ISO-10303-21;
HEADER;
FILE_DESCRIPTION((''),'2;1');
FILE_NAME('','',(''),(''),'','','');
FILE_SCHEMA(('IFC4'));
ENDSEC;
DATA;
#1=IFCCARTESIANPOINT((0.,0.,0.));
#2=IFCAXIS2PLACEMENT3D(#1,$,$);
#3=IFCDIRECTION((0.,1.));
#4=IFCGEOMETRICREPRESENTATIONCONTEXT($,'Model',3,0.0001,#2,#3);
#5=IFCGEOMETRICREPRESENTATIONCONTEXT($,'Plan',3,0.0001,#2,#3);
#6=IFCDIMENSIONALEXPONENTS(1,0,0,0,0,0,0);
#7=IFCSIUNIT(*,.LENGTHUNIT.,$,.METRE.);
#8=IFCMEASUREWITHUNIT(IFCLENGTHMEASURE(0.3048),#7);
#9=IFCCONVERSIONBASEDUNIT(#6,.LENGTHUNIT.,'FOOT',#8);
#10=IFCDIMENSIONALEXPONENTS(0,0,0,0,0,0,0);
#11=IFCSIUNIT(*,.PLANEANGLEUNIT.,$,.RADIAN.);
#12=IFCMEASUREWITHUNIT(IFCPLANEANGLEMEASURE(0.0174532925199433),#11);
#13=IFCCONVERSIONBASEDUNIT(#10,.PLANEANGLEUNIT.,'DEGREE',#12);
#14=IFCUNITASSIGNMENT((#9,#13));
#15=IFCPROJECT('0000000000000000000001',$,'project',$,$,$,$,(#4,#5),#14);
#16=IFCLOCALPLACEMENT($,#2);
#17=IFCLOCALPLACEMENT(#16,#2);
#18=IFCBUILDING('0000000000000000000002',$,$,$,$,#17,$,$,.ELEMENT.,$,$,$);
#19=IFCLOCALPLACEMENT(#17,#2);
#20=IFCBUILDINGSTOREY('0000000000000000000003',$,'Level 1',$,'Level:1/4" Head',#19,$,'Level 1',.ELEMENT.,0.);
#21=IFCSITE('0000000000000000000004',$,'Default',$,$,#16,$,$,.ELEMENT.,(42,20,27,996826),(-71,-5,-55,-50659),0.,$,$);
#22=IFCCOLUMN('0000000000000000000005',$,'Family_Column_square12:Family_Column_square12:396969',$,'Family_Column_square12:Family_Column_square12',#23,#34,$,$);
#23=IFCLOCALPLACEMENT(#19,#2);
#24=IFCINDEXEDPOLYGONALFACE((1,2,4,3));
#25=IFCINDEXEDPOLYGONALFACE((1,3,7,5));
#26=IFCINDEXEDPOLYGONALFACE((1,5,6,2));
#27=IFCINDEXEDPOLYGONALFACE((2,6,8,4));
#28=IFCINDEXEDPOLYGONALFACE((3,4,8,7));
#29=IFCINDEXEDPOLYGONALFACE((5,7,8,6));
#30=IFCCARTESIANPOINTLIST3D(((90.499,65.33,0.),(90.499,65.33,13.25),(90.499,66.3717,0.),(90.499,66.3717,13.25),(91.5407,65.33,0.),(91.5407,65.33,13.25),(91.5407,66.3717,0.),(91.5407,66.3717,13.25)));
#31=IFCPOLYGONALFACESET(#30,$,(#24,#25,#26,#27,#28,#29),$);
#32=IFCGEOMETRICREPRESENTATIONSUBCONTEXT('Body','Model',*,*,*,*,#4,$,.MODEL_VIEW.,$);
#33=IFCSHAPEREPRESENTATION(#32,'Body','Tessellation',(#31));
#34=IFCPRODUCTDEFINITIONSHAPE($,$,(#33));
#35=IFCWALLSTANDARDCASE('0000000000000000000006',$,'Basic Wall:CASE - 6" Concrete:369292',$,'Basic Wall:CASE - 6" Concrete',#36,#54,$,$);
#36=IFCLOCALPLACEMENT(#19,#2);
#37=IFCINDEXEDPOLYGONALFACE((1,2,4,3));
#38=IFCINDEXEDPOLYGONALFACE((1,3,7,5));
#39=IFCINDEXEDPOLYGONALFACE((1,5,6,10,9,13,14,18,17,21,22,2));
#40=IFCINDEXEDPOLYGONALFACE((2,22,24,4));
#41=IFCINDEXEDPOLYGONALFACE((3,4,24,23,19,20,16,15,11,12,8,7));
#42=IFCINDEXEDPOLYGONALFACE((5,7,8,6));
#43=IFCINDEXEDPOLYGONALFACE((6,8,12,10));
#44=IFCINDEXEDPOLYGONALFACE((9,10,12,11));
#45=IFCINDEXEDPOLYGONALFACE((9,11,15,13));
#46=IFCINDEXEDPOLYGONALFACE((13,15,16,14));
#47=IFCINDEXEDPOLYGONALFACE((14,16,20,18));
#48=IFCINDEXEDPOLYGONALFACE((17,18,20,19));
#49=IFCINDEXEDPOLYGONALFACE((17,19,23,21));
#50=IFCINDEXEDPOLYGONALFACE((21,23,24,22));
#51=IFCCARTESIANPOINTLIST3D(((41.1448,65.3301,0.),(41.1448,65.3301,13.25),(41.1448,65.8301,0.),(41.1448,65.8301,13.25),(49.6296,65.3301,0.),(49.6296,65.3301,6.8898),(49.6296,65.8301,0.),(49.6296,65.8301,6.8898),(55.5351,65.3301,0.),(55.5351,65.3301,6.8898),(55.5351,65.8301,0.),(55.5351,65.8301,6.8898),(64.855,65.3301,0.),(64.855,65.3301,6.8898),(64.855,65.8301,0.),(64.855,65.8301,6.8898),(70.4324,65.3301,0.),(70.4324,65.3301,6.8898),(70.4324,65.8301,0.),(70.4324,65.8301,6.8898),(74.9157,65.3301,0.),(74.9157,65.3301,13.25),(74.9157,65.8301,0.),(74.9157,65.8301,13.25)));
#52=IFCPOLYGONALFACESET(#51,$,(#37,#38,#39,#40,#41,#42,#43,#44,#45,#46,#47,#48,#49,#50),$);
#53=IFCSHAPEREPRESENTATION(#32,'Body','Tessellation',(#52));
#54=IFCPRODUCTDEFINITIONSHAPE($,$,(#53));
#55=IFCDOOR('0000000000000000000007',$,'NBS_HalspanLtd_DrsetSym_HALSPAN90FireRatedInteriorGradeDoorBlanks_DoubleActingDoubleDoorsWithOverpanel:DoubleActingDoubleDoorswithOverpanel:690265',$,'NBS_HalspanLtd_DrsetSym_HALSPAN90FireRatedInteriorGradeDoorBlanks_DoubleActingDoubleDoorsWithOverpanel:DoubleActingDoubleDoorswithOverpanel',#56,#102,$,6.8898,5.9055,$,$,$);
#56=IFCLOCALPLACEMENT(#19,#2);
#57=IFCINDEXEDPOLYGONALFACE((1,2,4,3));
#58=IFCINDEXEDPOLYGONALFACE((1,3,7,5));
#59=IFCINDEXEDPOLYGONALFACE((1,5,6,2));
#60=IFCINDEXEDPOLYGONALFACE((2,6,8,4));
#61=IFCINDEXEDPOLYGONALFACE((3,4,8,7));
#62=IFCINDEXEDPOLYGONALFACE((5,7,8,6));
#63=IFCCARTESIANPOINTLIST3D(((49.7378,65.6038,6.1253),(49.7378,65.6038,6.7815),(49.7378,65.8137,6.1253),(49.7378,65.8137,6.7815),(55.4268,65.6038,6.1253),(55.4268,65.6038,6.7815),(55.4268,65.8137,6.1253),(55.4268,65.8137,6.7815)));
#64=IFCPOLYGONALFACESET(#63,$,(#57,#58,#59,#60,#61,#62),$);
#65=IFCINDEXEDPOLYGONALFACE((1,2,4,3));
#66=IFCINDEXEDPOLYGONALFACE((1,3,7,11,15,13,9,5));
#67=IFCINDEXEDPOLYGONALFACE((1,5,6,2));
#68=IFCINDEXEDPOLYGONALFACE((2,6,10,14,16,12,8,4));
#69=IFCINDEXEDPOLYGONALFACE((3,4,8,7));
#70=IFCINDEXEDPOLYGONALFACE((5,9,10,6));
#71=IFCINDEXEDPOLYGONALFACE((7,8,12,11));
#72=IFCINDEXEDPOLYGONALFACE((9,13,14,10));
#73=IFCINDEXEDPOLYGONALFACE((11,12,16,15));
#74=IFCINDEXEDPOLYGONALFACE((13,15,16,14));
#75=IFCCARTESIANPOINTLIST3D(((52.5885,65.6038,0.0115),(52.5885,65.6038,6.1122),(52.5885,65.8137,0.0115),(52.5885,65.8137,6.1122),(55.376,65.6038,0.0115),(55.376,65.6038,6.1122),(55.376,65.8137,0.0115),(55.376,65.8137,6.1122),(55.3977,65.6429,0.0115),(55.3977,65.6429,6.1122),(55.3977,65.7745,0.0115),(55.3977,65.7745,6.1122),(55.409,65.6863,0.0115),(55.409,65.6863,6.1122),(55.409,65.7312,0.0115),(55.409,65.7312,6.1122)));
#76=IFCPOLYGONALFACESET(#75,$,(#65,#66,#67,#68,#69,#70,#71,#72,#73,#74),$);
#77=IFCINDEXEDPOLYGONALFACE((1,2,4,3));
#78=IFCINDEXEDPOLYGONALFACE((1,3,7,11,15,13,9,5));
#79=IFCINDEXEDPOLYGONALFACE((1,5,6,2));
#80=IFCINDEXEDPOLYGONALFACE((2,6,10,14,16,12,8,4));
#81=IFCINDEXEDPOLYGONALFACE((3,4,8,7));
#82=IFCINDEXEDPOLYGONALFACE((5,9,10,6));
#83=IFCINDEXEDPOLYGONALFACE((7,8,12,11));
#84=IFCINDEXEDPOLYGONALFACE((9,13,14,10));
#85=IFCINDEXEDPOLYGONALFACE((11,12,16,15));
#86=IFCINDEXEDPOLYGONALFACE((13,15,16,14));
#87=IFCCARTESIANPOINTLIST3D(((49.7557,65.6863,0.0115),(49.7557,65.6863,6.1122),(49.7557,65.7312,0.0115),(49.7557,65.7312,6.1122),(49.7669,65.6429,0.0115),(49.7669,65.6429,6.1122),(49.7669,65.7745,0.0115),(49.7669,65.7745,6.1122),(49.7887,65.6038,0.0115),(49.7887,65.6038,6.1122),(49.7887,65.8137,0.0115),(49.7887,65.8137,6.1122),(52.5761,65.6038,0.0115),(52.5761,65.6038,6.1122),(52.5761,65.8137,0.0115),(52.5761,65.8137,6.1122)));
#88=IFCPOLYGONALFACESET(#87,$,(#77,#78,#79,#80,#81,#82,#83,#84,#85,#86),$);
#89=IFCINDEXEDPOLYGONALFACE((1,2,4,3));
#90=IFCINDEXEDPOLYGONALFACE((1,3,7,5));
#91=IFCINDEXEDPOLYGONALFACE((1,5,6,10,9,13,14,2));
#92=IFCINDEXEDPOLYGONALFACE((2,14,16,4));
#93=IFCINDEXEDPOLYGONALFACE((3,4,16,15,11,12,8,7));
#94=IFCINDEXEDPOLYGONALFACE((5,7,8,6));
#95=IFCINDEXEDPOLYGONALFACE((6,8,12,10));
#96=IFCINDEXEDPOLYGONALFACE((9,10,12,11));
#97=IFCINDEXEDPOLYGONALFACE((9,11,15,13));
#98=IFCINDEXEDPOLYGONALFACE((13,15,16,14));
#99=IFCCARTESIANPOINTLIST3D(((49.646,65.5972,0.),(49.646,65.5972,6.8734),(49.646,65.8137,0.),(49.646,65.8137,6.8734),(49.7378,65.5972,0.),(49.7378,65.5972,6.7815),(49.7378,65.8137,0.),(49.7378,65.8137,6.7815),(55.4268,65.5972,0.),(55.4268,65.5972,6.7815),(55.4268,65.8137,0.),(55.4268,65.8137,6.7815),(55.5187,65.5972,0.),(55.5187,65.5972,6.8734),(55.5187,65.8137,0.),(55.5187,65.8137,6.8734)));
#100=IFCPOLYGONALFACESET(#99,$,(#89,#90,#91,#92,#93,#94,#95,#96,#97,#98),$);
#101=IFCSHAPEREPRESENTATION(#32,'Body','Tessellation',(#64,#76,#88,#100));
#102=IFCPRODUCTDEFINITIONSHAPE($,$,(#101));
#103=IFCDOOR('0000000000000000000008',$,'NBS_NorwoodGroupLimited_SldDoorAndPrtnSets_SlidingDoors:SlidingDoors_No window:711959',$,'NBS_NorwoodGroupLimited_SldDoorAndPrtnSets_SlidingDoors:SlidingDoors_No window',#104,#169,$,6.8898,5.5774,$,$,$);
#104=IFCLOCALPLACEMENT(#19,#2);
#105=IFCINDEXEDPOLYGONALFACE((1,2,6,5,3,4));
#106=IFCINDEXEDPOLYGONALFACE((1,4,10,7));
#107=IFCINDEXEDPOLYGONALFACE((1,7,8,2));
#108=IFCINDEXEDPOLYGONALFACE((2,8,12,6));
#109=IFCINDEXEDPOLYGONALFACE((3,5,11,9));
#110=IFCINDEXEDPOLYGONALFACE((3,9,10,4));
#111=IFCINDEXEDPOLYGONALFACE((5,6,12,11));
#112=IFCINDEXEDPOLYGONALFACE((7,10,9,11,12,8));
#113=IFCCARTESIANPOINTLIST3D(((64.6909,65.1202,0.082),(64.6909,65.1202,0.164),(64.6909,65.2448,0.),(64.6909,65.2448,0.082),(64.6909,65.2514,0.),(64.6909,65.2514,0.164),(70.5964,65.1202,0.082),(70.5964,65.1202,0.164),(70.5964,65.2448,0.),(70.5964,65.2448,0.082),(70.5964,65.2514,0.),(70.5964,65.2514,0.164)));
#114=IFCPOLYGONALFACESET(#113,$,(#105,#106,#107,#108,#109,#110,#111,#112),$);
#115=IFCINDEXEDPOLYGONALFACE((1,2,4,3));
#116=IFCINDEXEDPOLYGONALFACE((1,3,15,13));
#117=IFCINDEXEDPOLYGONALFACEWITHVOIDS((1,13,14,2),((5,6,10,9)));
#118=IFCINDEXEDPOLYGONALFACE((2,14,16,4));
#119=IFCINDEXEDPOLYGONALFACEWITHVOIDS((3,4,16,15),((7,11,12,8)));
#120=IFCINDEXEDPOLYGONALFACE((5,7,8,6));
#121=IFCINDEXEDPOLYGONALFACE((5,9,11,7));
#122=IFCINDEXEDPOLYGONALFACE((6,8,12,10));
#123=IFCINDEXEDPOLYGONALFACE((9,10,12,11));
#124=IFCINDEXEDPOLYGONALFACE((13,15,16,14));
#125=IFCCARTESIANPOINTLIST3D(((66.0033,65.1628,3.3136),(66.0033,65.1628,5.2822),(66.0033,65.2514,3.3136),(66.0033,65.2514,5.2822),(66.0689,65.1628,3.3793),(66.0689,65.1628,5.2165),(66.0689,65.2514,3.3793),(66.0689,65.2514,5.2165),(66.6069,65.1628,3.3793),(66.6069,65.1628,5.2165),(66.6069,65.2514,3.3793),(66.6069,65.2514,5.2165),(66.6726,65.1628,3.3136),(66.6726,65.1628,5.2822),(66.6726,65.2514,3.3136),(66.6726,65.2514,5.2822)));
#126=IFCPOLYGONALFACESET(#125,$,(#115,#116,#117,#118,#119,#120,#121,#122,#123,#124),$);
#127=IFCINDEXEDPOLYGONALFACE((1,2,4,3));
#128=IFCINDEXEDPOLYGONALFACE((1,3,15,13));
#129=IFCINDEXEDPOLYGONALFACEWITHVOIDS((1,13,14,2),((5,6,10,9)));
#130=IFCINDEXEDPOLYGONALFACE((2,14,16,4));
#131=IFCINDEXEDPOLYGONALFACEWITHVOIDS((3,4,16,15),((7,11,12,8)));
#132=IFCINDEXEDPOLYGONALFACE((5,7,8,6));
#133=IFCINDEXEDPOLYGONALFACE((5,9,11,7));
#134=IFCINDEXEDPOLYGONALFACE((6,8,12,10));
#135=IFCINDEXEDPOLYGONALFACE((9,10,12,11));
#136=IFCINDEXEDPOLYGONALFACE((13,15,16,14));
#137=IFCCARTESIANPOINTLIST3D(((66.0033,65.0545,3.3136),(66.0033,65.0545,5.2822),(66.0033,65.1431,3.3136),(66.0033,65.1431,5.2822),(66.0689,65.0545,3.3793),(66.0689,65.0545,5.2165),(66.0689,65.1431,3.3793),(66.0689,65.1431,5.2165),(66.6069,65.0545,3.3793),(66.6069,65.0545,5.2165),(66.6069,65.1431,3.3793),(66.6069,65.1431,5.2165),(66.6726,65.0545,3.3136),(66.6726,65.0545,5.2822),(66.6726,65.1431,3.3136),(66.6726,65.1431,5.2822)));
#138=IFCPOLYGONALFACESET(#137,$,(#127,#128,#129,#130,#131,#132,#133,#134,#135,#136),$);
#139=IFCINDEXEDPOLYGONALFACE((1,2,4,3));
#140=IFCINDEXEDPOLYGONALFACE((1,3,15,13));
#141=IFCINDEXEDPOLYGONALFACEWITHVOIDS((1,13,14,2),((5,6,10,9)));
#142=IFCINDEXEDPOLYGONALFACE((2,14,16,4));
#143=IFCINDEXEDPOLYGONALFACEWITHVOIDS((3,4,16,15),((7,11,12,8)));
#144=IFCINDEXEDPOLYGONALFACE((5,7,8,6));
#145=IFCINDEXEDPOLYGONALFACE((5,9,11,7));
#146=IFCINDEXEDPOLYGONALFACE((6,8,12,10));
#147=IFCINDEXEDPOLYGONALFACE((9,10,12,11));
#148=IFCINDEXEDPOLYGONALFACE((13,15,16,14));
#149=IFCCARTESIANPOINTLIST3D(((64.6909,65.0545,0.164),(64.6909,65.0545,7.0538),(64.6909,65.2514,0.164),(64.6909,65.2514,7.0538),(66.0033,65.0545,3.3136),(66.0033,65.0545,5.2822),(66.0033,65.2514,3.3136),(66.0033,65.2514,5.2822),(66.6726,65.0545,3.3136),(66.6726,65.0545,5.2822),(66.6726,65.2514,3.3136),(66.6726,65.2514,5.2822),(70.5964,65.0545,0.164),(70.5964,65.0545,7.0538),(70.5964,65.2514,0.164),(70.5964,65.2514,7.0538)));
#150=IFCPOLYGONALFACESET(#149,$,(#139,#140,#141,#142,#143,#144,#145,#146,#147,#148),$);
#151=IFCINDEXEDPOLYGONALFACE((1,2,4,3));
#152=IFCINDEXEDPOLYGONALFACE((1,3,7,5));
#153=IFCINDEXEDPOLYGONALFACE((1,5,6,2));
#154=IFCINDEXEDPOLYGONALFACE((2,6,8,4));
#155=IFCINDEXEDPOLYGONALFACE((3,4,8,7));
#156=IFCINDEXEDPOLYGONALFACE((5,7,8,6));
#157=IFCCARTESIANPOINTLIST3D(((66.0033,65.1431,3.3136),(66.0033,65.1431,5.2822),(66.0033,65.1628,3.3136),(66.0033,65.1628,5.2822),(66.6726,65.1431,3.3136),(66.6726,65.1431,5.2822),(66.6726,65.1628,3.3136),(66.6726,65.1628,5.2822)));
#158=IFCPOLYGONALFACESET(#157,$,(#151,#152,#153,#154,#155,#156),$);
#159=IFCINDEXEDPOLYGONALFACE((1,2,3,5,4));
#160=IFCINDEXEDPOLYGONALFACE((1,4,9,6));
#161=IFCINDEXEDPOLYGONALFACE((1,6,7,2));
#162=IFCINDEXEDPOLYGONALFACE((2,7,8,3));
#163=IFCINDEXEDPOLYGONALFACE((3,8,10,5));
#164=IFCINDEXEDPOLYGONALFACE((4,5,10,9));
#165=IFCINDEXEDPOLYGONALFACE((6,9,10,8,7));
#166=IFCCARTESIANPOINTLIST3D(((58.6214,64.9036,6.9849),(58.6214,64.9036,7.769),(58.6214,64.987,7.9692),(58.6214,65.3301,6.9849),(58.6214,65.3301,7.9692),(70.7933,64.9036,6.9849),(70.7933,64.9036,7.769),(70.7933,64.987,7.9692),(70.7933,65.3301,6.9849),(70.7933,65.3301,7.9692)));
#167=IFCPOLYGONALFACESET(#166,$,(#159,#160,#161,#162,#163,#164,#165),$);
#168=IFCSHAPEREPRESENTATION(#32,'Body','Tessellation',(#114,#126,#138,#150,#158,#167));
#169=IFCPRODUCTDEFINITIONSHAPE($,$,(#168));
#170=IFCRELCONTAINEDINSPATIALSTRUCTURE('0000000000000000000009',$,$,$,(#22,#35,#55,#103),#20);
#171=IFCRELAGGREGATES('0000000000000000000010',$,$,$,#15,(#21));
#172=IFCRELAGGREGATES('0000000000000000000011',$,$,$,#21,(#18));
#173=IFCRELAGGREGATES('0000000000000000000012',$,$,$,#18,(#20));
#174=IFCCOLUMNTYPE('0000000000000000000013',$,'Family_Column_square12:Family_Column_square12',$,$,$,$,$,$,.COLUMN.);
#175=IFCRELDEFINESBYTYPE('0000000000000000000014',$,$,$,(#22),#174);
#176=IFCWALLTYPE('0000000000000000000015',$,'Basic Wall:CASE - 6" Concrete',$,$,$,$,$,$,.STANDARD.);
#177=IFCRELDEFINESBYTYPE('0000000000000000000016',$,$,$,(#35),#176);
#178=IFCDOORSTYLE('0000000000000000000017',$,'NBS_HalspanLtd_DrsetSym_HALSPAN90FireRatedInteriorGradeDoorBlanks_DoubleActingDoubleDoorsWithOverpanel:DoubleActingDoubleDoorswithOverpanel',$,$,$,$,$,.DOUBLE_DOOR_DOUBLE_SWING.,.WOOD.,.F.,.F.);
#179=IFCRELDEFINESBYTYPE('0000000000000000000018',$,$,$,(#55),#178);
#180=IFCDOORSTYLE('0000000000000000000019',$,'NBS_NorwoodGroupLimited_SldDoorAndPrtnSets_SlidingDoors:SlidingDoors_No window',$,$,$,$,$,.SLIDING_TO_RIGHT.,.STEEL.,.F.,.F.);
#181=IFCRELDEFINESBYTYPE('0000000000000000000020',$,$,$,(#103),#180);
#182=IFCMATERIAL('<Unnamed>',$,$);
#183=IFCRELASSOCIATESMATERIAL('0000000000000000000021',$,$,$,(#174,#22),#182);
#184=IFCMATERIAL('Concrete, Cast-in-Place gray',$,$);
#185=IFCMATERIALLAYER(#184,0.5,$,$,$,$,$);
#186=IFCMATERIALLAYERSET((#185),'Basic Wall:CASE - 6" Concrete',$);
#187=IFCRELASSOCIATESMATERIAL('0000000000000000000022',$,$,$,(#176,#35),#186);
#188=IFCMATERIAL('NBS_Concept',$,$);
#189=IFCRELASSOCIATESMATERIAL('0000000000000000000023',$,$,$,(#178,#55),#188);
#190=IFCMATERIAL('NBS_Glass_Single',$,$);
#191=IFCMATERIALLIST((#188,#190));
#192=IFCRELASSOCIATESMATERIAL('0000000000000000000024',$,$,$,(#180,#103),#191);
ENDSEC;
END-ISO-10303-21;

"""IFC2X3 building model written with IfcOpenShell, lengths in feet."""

from ifc_helpers import new_model, entity, si_unit, converted_unit, direction, frame, frame_2d, origin, origin_2d_with_axis, place, context, subcontext, project, spatial, polyline, circle_curve, parameter, trimmed, segment, composite_curve, rectangle, outline, extrude, source, transform, mapped, material, material_list, layer, layer_set, layer_usage, type_object, type_shapes, element, fill, save


model = new_model("IFC2X3")

# Units and contexts
model_context = context("Model", 3, precision=0.0001, world=origin(), true_north=direction((0.0, 1.0)))
plan_context = context("Plan", 3, precision=0.0001, world=origin(), true_north=direction((0.0, 1.0)))
body_context = subcontext(model_context, "Body", "Model", "MODEL_VIEW")
ifc_project = project(units=[converted_unit("LENGTHUNIT", "FOOT", entity("IfcLengthMeasure", 0.3048), si_unit("LENGTHUNIT", "METRE"), dimensions=[1, 0, 0, 0, 0, 0, 0]), converted_unit("PLANEANGLEUNIT", "DEGREE", entity("IfcPlaneAngleMeasure", 0.0174532925199433), si_unit("PLANEANGLEUNIT", "RADIAN"), dimensions=[0, 0, 0, 0, 0, 0, 0])], contexts=[model_context, plan_context])

# Site, building, storey
site_placement = place(None, origin())
site = spatial("IfcSite", under=ifc_project, at=site_placement, Name="Default", CompositionType="ELEMENT", RefLatitude=(42, 20, 27, 996826), RefLongitude=(-71, -5, -55, -50659), RefElevation=0.0)
building_placement = place(site_placement, origin())
building = spatial("IfcBuilding", under=site, at=building_placement, CompositionType="ELEMENT")
storey_placement = place(building_placement, origin())
storey = spatial("IfcBuildingStorey", under=building, at=storey_placement, Name="Level 1", ObjectType="Level:1/4\" Head", LongName="Level 1", CompositionType="ELEMENT", Elevation=0.0)

# Column
ifc_material_1 = material(Name="<Unnamed>")
column_type = type_object("IfcColumnType", Name="Family_Column_square12:Family_Column_square12", PredefinedType="COLUMN", material=ifc_material_1)
shared_shape_1 = source(origin(), body_context, "Body", "SweptSolid", [
    extrude(rectangle(XDim=1.0417, YDim=1.0417, at=frame_2d((0.0, 0.0), x_axis=(1.0, 0.0))), frame((0.0, 0.0, 0.0), z_axis=(0.0, 0.0, 1.0), x_axis=(-1.0, 0.0, 0.0)), (0.0, 0.0, 1.0), 13.25),
])
type_shapes(column_type, [shared_shape_1])
column_placement = place(storey_placement, frame((91.0198, 65.8509, 0.0)))
element("IfcColumn", 1, at=column_placement, inside=storey, type_object=column_type, material=ifc_material_1, Name="Family_Column_square12:Family_Column_square12:396969", ObjectType="Family_Column_square12:Family_Column_square12", context=body_context, shape_type="MappedRepresentation", body=[
    mapped(shared_shape_1, transform((0.0, 0.0, 0.0), scale=1.0)),
])

# Wall, openings, doors
ifc_material_2 = material(Name="Concrete, Cast-in-Place gray")
ifc_layer = layer(ifc_material_2, 0.5)
ifc_layer_set = layer_set([ifc_layer], Name="Basic Wall:CASE - 6\" Concrete")
ifc_layer_usage_1 = layer_usage(ifc_layer_set, "AXIS2", "NEGATIVE", 0.25)
wall_type = type_object("IfcWallType", Name="Basic Wall:CASE - 6\" Concrete", PredefinedType="STANDARD", material=ifc_layer_set)
wall_1_placement = place(storey_placement, frame((74.9157, 65.5801, 0.0), z_axis=(0.0, 0.0, 1.0), x_axis=(-1.0, 0.0, 0.0)))
wall_1 = element("IfcWallStandardCase", 2, at=wall_1_placement, inside=storey, type_object=wall_type, material=ifc_layer_usage_1, Name="Basic Wall:CASE - 6\" Concrete:369292", ObjectType="Basic Wall:CASE - 6\" Concrete", context=body_context, shape_type="SweptSolid", body=[
    extrude(rectangle(XDim=33.7708, YDim=0.5, at=frame_2d((16.8854, 0.0), x_axis=(1.0, 0.0))), origin(), (0.0, 0.0, 1.0), 13.25),
])
opening_1_placement = place(wall_1_placement, frame((74.9157, 65.5801, 0.0), z_axis=(0.0, 0.0, 1.0), x_axis=(-1.0, 0.0, 0.0)))
opening_1 = element("IfcOpeningElement", 3, at=opening_1_placement, cuts=wall_1, ObjectType="Opening", context=body_context, shape_type="SweptSolid", body=[
    extrude(rectangle(XDim=6.8898, YDim=5.9055, at=frame_2d((0.0, 0.0), x_axis=(0.0, 1.0))), frame((52.5823, 65.8465, 3.4449), z_axis=(0.0, -1.0, 0.0), x_axis=(-1.0, 0.0, 0.0)), (0.0, 0.0, 1.0), 0.5328),
])
opening_2_placement = place(wall_1_placement, frame((10.0607, 0.25, 0.0)))
opening_2 = element("IfcOpeningElement", 4, at=opening_2_placement, cuts=wall_1, ObjectType="Opening", context=body_context, shape_type="SweptSolid", body=[
    extrude(rectangle(XDim=5.5774, YDim=6.8898, at=frame_2d((3.4449, 2.7887), x_axis=(0.0, -1.0))), frame((0.0, 0.0, 0.0), z_axis=(0.0, -1.0, 0.0), x_axis=(0.0, 0.0, 1.0)), (0.0, 0.0, 1.0), 0.5),
])
ifc_material_3 = material(Name="NBS_Concept")
door_style_1 = type_object("IfcDoorStyle", Name="NBS_HalspanLtd_DrsetSym_HALSPAN90FireRatedInteriorGradeDoorBlanks_DoubleActingDoubleDoorsWithOverpanel:DoubleActingDoubleDoorswithOverpanel", ConstructionType="WOOD", OperationType="DOUBLE_DOOR_DOUBLE_SWING", ParameterTakesPrecedence=False, Sizeable=False, material=ifc_material_3)
shared_shape_2 = source(origin(), body_context, "Body", "SweptSolid", [
    extrude(rectangle(XDim=5.689, YDim=0.21, at=frame_2d((0.0, 0.0), x_axis=(1.0, 0.0))), frame((2.9528, -0.1378, 6.1253), z_axis=(0.0, 0.0, 1.0), x_axis=(-1.0, 0.0, 0.0)), (0.0, 0.0, 1.0), 0.6562),
    extrude(outline(composite_curve([segment(polyline([(-0.105, -1.3937), (0.105, -1.3937)]), True, "CONTINUOUS"), segment(polyline([(0.105, -1.3937), (0.105, 1.3937)]), True, "CONTINUOUS"), segment(trimmed(circle_curve(frame_2d((0.0, 1.251), x_axis=(0.0, 1.0)), 0.1772), [parameter(323.658797)], [parameter(36.341203)], True, "PARAMETER"), True, "CONTINUOUS"), segment(polyline([(-0.105, 1.3937), (-0.105, -1.3937)]), True, "CONTINUOUS")], self_intersect=False)), frame((4.3527, -0.1378, 0.0115), z_axis=(0.0, 0.0, 1.0), x_axis=(0.0, -1.0, 0.0)), (0.0, 0.0, 1.0), 6.1007),
    extrude(outline(composite_curve([segment(polyline([(-0.105, -1.3937), (0.105, -1.3937)]), True, "CONTINUOUS"), segment(polyline([(0.105, -1.3937), (0.105, 1.3937)]), True, "CONTINUOUS"), segment(trimmed(circle_curve(frame_2d((0.0, 1.251), x_axis=(0.0, -1.0)), 0.1772), [parameter(143.658797)], [parameter(216.341203)], True, "PARAMETER"), True, "CONTINUOUS"), segment(polyline([(-0.105, 1.3937), (-0.105, -1.3937)]), True, "CONTINUOUS")], self_intersect=False)), frame((1.5528, -0.1378, 0.0115), z_axis=(0.0, 0.0, 1.0), x_axis=(0.0, 1.0, 0.0)), (0.0, 0.0, 1.0), 6.1007),
    extrude(outline(polyline([(-3.4137, -2.8445), (-3.4137, -2.9364), (3.4596, -2.9364), (3.4596, 2.9364), (-3.4137, 2.9364), (-3.4137, 2.8445), (3.3678, 2.8445), (3.3678, -2.8445), (-3.4137, -2.8445)])), frame((2.9528, -0.2493, 3.4137), z_axis=(0.0, -1.0, 0.0), x_axis=(0.0, 0.0, 1.0)), (0.0, 0.0, -1.0), 0.2165),
])
type_shapes(door_style_1, [shared_shape_2])
door_1_placement = place(opening_1_placement, frame((49.6296, 65.8465, 0.0)))
door_1 = element("IfcDoor", 5, at=door_1_placement, inside=storey, type_object=door_style_1, material=ifc_material_3, Name="NBS_HalspanLtd_DrsetSym_HALSPAN90FireRatedInteriorGradeDoorBlanks_DoubleActingDoubleDoorsWithOverpanel:DoubleActingDoubleDoorswithOverpanel:690265", ObjectType="NBS_HalspanLtd_DrsetSym_HALSPAN90FireRatedInteriorGradeDoorBlanks_DoubleActingDoubleDoorsWithOverpanel:DoubleActingDoubleDoorswithOverpanel", OverallHeight=6.8898, OverallWidth=5.9055, context=body_context, shape_type="MappedRepresentation", body=[
    mapped(shared_shape_2, transform((0.0, 0.0, 0.0), scale=1.0)),
])
fill(opening_1, door_1)
ifc_material_4 = material(Name="NBS_Glass_Single")
ifc_material_list = material_list([ifc_material_3, ifc_material_4])
door_style_2 = type_object("IfcDoorStyle", Name="NBS_NorwoodGroupLimited_SldDoorAndPrtnSets_SlidingDoors:SlidingDoors_No window", ConstructionType="STEEL", OperationType="SLIDING_TO_RIGHT", ParameterTakesPrecedence=False, Sizeable=False, material=ifc_material_list)
shared_shape_3 = source(origin(), body_context, "Body", "SweptSolid", [
    extrude(outline(polyline([(-0.082, -0.0394), (-0.082, -0.0459), (0.082, -0.0459), (0.082, 0.0853), (0.0, 0.0853), (0.0, -0.0394), (-0.082, -0.0394)])), frame((5.7415, -0.1247, 0.082), z_axis=(1.0, 0.0, 0.0), x_axis=(0.0, 0.0, 1.0)), (0.0, 0.0, -1.0), 5.9055),
    extrude(outline(polyline([(-0.9843, -0.3346), (0.9843, -0.3346), (0.9843, 0.3346), (-0.9843, 0.3346), (-0.9843, -0.3346)]), holes=[polyline([(-0.9186, 0.269), (0.9186, 0.269), (0.9186, -0.269), (-0.9186, -0.269), (-0.9186, 0.269)])]), frame((1.4829, -0.0787, 4.2979), z_axis=(0.0, -1.0, 0.0), x_axis=(0.0, 0.0, -1.0)), (0.0, 0.0, 1.0), 0.0886),
    extrude(outline(polyline([(-0.9843, -0.3346), (0.9843, -0.3346), (0.9843, 0.3346), (-0.9843, 0.3346), (-0.9843, -0.3346)]), holes=[polyline([(-0.9186, 0.269), (0.9186, 0.269), (0.9186, -0.269), (-0.9186, -0.269), (-0.9186, 0.269)])]), frame((1.4829, -0.187, 4.2979), z_axis=(0.0, -1.0, 0.0), x_axis=(0.0, 0.0, -1.0)), (0.0, 0.0, 1.0), 0.0886),
    extrude(outline(polyline([(-2.9528, -3.4449), (2.9528, -3.4449), (2.9528, 3.4449), (-2.9528, 3.4449), (-2.9528, -3.4449)]), holes=[polyline([(1.6404, -1.6732), (0.9711, -1.6732), (0.9711, 0.2953), (1.6404, 0.2953), (1.6404, -1.6732)])]), frame((2.7887, -0.0787, 3.6089), z_axis=(0.0, -1.0, 0.0), x_axis=(-1.0, 0.0, 0.0)), (0.0, 0.0, 1.0), 0.1969),
    extrude(rectangle(XDim=0.6693, YDim=0.0197, at=origin_2d_with_axis()), frame((1.4829, -0.1772, 3.3136), z_axis=(0.0, 0.0, 1.0), x_axis=(-1.0, 0.0, 0.0)), (0.0, 0.0, 1.0), 1.9685),
    extrude(outline(polyline([(-0.1039, -0.4337), (0.2392, -0.4337), (0.2392, 0.5505), (-0.1873, 0.5505), (-0.1873, -0.2336), (-0.1039, -0.4337)])), frame((5.9383, -0.2392, 7.5354), z_axis=(-1.0, 0.0, 0.0), x_axis=(0.0, 1.0, 0.0)), (0.0, 0.0, 1.0), 12.1719),
])
type_shapes(door_style_2, [shared_shape_3])
door_2_placement = place(opening_2_placement, frame((0.0, 0.0, 0.0), z_axis=(0.0, 0.0, 1.0), x_axis=(-1.0, 0.0, 0.0)))
door_2 = element("IfcDoor", 6, at=door_2_placement, inside=storey, type_object=door_style_2, material=ifc_material_list, Name="NBS_NorwoodGroupLimited_SldDoorAndPrtnSets_SlidingDoors:SlidingDoors_No window:711959", ObjectType="NBS_NorwoodGroupLimited_SldDoorAndPrtnSets_SlidingDoors:SlidingDoors_No window", OverallHeight=6.8898, OverallWidth=5.5774, context=body_context, shape_type="MappedRepresentation", body=[
    mapped(shared_shape_3, transform((0.0, 0.0, 0.0), scale=1.0)),
])
fill(opening_2, door_2)

save(model, "model.ifc")
